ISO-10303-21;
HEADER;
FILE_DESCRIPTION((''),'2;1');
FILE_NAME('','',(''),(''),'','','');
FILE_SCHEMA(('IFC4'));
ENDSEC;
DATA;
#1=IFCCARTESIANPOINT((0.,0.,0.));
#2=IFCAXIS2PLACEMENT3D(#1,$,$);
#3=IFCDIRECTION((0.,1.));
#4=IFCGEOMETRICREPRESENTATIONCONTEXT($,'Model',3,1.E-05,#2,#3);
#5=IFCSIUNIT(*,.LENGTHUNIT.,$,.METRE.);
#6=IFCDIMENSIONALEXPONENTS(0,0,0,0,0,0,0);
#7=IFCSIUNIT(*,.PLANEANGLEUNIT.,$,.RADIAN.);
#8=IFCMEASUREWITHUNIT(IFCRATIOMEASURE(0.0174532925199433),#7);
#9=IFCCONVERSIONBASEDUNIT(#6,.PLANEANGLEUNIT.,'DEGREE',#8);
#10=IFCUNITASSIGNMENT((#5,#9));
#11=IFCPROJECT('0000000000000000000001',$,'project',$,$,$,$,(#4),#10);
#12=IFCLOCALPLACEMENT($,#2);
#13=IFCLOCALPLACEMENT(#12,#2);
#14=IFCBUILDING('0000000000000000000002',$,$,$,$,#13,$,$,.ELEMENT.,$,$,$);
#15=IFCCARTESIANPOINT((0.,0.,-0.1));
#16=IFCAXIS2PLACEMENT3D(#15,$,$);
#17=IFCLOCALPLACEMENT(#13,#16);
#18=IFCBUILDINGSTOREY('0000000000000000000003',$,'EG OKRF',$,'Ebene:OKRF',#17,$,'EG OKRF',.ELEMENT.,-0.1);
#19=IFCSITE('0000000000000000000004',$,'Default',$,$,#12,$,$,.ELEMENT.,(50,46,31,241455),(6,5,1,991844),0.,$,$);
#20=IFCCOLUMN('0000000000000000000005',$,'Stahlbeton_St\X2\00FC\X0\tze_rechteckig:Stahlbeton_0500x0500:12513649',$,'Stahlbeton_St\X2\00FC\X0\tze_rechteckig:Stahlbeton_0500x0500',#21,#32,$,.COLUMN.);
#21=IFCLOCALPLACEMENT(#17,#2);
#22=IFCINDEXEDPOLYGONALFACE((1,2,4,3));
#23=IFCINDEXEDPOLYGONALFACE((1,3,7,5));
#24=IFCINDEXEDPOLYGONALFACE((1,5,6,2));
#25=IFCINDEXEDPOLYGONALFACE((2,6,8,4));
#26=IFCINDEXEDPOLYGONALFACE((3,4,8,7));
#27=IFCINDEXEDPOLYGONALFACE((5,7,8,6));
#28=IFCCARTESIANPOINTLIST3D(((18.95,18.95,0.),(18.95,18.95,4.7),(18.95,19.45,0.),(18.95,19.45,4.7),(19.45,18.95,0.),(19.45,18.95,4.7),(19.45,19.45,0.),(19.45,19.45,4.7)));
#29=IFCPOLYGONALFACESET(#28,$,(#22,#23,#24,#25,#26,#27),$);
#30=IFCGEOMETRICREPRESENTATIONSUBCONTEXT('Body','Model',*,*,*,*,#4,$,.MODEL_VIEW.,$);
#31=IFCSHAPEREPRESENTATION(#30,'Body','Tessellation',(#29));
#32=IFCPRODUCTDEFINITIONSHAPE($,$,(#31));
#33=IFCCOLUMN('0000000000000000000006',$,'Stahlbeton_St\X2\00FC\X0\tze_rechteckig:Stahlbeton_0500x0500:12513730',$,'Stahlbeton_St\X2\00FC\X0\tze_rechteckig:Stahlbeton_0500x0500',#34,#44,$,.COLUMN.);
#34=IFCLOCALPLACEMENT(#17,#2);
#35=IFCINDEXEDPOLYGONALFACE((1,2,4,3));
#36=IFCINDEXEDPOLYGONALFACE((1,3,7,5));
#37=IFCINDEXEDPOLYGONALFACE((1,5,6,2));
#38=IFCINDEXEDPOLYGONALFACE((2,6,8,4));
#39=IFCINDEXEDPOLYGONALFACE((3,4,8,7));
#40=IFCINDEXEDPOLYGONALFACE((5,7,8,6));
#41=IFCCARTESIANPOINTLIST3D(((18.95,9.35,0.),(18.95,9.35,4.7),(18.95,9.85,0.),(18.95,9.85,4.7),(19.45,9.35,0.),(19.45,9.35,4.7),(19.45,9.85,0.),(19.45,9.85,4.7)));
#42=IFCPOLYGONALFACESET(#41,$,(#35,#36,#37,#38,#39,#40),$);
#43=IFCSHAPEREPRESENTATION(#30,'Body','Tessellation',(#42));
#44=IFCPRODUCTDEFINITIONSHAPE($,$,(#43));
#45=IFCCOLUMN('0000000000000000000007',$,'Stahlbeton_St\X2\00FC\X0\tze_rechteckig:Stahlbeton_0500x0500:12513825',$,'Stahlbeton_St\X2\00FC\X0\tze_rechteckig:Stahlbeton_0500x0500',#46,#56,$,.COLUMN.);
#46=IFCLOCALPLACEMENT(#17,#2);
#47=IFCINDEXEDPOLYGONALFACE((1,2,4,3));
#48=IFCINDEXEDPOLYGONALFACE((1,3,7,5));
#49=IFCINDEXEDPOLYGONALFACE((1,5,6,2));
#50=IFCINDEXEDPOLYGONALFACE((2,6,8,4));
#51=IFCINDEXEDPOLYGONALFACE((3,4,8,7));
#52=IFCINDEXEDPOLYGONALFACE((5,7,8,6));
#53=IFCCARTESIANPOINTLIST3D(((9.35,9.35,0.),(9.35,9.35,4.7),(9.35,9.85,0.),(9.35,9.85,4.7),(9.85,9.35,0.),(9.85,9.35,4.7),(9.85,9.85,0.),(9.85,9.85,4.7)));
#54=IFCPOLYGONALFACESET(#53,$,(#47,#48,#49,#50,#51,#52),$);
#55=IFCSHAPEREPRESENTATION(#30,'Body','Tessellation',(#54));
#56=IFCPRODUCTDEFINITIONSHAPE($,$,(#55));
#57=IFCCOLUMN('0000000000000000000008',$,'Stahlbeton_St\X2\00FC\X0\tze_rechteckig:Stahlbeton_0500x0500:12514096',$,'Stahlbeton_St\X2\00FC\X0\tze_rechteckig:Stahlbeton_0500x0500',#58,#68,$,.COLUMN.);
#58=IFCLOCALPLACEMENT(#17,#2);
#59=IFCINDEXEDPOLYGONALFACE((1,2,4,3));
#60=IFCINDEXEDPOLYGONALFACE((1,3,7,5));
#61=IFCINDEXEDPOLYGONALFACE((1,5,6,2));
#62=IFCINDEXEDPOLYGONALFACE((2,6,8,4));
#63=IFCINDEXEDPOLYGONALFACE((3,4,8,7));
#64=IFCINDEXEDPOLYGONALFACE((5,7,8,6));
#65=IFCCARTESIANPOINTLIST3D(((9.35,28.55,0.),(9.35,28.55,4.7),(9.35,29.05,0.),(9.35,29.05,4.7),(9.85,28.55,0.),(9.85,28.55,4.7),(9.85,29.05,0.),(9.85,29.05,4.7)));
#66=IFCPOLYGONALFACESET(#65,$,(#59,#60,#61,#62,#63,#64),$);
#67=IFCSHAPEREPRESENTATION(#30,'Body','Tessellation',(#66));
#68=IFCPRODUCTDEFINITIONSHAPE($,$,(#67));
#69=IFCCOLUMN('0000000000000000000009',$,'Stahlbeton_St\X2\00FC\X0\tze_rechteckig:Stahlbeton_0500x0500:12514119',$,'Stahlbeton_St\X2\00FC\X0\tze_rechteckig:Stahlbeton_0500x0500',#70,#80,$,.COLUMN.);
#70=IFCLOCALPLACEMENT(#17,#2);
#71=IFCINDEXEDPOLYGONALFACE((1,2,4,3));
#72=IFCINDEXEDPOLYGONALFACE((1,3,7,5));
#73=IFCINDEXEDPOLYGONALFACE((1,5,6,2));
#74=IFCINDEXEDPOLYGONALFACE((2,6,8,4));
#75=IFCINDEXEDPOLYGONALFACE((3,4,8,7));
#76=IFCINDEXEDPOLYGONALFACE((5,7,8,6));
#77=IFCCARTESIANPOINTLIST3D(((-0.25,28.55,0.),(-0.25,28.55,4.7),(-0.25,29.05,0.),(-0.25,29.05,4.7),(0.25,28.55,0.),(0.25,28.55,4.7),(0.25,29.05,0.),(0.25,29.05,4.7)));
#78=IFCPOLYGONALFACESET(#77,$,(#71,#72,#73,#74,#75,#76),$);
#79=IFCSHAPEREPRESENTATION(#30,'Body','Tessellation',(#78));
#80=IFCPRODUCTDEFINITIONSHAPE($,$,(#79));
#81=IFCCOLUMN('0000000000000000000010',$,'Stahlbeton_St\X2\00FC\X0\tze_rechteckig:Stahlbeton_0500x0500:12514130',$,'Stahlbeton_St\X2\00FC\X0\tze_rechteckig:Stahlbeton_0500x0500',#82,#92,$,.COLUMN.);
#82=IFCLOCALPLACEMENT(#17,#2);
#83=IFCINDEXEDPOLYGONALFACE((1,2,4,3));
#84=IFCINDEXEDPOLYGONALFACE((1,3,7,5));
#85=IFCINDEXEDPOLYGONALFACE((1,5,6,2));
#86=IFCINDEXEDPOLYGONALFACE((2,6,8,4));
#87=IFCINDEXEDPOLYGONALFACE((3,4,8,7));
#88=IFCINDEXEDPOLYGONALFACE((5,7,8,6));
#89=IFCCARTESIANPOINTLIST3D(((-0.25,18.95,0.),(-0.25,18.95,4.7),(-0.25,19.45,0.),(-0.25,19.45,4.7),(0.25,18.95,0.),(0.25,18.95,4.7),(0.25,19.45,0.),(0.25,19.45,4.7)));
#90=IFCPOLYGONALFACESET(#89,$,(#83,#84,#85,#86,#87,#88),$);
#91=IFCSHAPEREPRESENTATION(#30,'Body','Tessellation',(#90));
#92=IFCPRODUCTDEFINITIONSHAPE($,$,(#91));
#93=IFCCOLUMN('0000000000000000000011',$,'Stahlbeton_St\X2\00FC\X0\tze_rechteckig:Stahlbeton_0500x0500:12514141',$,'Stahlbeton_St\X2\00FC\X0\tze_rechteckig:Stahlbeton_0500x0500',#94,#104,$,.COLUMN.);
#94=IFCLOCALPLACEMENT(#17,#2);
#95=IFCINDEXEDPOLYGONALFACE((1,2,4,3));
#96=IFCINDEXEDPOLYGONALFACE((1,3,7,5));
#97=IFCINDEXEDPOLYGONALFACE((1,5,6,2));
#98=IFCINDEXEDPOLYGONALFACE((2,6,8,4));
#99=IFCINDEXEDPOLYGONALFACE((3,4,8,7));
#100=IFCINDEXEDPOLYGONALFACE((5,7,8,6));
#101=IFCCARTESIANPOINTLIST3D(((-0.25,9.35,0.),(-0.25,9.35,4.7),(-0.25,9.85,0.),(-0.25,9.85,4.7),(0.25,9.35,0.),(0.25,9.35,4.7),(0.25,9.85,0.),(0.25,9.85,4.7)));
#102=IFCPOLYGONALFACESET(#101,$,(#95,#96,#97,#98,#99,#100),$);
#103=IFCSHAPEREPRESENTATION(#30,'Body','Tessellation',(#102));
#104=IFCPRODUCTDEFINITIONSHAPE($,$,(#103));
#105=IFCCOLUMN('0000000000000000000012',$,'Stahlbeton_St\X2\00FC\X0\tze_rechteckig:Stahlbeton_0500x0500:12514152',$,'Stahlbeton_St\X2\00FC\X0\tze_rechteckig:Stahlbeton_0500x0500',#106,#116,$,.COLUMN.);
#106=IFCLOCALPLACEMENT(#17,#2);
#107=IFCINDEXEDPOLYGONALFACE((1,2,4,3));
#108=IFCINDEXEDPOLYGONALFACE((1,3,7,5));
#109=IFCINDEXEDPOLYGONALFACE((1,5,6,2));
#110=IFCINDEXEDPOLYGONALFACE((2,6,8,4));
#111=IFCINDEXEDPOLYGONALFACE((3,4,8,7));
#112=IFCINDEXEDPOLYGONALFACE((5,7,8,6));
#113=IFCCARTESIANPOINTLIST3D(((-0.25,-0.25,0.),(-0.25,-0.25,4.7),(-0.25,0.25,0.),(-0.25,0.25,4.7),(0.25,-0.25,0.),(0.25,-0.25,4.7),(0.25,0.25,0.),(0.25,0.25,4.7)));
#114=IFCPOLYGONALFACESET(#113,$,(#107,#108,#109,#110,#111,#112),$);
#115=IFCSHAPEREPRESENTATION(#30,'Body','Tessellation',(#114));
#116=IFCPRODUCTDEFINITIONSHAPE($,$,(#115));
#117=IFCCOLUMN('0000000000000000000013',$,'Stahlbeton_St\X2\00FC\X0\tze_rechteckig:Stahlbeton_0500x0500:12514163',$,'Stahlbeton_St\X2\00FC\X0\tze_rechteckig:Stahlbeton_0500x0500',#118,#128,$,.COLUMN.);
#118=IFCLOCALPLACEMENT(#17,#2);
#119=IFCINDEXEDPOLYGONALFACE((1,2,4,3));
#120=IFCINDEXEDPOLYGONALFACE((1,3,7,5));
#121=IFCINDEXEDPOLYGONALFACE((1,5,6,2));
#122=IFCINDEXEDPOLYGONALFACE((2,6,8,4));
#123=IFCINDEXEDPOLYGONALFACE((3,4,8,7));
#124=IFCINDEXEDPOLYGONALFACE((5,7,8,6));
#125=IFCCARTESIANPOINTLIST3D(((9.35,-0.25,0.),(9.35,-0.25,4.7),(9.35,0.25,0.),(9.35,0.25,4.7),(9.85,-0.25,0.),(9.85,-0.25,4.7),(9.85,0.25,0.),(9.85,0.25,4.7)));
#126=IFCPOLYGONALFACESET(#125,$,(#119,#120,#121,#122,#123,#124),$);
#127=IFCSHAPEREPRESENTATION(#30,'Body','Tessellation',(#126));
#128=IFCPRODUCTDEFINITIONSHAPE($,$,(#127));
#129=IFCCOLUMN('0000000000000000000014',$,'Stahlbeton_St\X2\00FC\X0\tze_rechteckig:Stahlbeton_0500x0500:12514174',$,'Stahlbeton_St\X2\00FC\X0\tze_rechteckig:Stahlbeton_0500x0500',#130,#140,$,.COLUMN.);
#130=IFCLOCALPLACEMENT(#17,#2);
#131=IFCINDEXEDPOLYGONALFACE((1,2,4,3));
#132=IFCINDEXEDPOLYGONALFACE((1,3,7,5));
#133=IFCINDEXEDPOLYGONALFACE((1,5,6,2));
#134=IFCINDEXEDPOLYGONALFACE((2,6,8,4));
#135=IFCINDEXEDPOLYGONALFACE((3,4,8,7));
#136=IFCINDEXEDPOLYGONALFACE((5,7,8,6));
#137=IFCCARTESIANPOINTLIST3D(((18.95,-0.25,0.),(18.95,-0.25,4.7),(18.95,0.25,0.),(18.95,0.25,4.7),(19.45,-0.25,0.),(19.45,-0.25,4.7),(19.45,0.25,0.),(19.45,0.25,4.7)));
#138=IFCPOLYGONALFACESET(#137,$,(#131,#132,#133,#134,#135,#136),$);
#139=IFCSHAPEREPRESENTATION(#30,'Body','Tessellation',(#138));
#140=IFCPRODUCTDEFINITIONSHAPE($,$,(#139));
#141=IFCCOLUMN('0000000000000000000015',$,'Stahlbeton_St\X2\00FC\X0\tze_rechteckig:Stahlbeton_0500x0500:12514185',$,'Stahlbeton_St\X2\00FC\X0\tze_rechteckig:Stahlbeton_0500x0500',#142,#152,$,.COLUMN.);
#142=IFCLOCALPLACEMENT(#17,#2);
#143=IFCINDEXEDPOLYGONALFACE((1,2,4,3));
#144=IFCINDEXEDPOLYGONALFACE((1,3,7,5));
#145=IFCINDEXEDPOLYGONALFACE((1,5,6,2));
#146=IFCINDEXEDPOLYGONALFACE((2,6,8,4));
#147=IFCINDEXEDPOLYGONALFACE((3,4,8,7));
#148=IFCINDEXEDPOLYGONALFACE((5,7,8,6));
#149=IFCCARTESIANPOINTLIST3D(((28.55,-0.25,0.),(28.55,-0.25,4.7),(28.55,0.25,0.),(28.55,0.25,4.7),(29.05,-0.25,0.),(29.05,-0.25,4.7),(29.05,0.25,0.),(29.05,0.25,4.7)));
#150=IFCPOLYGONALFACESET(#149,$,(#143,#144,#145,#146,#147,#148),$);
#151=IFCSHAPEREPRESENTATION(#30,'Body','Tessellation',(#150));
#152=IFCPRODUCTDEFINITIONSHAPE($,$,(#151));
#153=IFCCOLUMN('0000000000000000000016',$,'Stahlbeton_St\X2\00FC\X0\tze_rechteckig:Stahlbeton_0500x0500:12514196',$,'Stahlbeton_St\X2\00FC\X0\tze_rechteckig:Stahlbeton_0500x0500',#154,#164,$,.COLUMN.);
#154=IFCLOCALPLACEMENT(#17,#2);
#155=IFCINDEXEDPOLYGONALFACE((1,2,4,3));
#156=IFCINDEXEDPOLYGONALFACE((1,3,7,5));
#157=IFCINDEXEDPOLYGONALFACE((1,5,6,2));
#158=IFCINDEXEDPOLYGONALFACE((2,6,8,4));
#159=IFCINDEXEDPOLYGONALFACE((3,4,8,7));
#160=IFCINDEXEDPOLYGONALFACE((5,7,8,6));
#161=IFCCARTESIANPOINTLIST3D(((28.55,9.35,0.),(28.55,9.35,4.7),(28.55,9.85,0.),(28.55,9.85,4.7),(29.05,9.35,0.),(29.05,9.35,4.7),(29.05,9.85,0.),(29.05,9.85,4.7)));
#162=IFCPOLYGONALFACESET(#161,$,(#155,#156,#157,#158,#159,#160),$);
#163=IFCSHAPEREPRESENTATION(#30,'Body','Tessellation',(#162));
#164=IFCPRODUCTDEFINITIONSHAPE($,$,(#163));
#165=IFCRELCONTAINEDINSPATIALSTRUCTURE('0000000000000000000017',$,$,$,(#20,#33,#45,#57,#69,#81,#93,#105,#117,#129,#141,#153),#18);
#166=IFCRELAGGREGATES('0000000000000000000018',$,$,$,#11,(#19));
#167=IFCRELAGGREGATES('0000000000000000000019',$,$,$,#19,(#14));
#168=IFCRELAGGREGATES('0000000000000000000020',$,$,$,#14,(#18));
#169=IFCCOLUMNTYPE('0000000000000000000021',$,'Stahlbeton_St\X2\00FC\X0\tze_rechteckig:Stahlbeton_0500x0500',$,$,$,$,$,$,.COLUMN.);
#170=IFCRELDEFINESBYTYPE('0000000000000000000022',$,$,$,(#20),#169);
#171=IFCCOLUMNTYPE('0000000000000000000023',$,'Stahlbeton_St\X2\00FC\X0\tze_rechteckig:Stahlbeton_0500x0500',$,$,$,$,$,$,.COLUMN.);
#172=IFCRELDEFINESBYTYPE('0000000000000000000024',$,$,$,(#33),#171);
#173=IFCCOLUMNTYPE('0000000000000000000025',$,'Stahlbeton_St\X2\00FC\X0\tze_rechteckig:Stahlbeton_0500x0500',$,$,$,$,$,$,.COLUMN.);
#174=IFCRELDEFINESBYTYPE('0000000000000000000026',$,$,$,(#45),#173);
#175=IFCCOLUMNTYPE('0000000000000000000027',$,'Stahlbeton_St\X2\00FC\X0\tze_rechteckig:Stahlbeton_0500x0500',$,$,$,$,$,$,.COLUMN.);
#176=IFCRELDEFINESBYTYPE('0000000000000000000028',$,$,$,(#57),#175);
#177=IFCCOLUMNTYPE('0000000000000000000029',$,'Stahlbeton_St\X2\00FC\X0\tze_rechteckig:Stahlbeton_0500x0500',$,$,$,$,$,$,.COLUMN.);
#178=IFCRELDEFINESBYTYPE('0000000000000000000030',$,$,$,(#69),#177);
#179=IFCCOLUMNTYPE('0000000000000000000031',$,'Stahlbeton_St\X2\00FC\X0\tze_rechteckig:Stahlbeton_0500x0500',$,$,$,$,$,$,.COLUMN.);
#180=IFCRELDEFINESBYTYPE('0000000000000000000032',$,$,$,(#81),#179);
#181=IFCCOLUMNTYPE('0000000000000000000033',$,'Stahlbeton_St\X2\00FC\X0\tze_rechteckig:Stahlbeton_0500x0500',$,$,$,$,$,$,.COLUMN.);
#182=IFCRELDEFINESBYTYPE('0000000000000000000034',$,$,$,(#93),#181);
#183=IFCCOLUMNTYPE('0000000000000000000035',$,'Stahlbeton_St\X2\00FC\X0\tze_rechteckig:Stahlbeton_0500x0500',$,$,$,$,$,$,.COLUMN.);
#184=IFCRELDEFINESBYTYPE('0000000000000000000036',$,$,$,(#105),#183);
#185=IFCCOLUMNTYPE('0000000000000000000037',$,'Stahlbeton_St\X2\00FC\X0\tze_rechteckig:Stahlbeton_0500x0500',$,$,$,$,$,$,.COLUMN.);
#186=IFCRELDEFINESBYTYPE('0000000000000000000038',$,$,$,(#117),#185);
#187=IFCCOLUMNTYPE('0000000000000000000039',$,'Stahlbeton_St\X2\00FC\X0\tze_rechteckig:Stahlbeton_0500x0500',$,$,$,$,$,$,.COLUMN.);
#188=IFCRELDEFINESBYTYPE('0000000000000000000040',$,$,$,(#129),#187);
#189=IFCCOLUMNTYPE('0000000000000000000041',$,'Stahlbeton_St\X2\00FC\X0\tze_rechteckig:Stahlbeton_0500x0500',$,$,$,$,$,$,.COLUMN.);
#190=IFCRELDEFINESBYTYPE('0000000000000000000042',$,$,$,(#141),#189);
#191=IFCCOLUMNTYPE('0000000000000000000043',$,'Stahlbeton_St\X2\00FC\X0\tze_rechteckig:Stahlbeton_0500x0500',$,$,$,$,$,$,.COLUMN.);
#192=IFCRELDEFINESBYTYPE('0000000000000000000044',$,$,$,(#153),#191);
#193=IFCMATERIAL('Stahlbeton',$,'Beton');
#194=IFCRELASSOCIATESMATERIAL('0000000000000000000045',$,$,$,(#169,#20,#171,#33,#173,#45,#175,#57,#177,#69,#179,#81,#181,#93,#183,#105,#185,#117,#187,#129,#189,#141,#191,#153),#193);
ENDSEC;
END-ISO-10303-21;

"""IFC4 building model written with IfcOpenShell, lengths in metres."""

from ifc_helpers import new_model, entity, si_unit, converted_unit, direction, frame, origin, place, context, subcontext, project, spatial, indexed_curve, outline, extrude, source, transform, mapped, material, type_object, type_shapes, element, save


model = new_model("IFC4")

# Units and contexts
model_context = context("Model", 3, precision=1e-05, world=origin(), true_north=direction((0.0, 1.0)))
body_context = subcontext(model_context, "Body", "Model", "MODEL_VIEW")
ifc_project = project(units=[si_unit("LENGTHUNIT", "METRE"), converted_unit("PLANEANGLEUNIT", "DEGREE", entity("IfcRatioMeasure", 0.0174532925199433), si_unit("PLANEANGLEUNIT", "RADIAN"), dimensions=[0, 0, 0, 0, 0, 0, 0])], contexts=[model_context])

# Site, building, storey
site_placement = place(None, origin())
site = spatial("IfcSite", under=ifc_project, at=site_placement, Name="Default", CompositionType="ELEMENT", RefLatitude=(50, 46, 31, 241455), RefLongitude=(6, 5, 1, 991844), RefElevation=0.0)
building_placement = place(site_placement, origin())
building = spatial("IfcBuilding", under=site, at=building_placement, CompositionType="ELEMENT")
storey_placement = place(building_placement, frame((0.0, 0.0, -0.1)))
storey = spatial("IfcBuildingStorey", under=building, at=storey_placement, Name="EG OKRF", ObjectType="Ebene:OKRF", LongName="EG OKRF", CompositionType="ELEMENT", Elevation=-0.1)

# Columns
ifc_material_1 = material(Name="Stahlbeton", Category="Beton")
column_type_1 = type_object("IfcColumnType", Name="Stahlbeton_Stütze_rechteckig:Stahlbeton_0500x0500", PredefinedType="COLUMN", material=ifc_material_1)
shared_shape_1 = source(origin(), body_context, "Body", "SweptSolid", [
    extrude(outline(indexed_curve([(-0.25, -0.25), (0.25, -0.25), (0.25, 0.25), (-0.25, 0.25), (-0.25, -0.25)], self_intersect=False)), frame((19.2, 19.2, -0.1), z_axis=(0.0, 0.0, 1.0), x_axis=(0.0, -1.0, 0.0)), (0.0, 0.0, 1.0), 4.7),
])
type_shapes(column_type_1, [shared_shape_1])
column_1_placement = place(storey_placement, frame((0.0, 0.0, 0.1)))
element("IfcColumn", 1, at=column_1_placement, inside=storey, type_object=column_type_1, material=ifc_material_1, Name="Stahlbeton_Stütze_rechteckig:Stahlbeton_0500x0500:12513649", ObjectType="Stahlbeton_Stütze_rechteckig:Stahlbeton_0500x0500", PredefinedType="COLUMN", context=body_context, shape_type="MappedRepresentation", body=[
    mapped(shared_shape_1, transform((0.0, 0.0, 0.0), scale=1.0)),
])
column_type_2 = type_object("IfcColumnType", Name="Stahlbeton_Stütze_rechteckig:Stahlbeton_0500x0500", PredefinedType="COLUMN", material=ifc_material_1)
shared_shape_2 = source(origin(), body_context, "Body", "SweptSolid", [
    extrude(outline(indexed_curve([(-0.25, -0.25), (0.25, -0.25), (0.25, 0.25), (-0.25, 0.25), (-0.25, -0.25)], self_intersect=False)), frame((19.2, 9.6, -0.1), z_axis=(0.0, 0.0, 1.0), x_axis=(0.0, -1.0, 0.0)), (0.0, 0.0, 1.0), 4.7),
])
type_shapes(column_type_2, [shared_shape_2])
column_2_placement = place(storey_placement, frame((0.0, 0.0, 0.1)))
element("IfcColumn", 2, at=column_2_placement, inside=storey, type_object=column_type_2, material=ifc_material_1, Name="Stahlbeton_Stütze_rechteckig:Stahlbeton_0500x0500:12513730", ObjectType="Stahlbeton_Stütze_rechteckig:Stahlbeton_0500x0500", PredefinedType="COLUMN", context=body_context, shape_type="MappedRepresentation", body=[
    mapped(shared_shape_2, transform((0.0, 0.0, 0.0), scale=1.0)),
])
column_type_3 = type_object("IfcColumnType", Name="Stahlbeton_Stütze_rechteckig:Stahlbeton_0500x0500", PredefinedType="COLUMN", material=ifc_material_1)
shared_shape_3 = source(origin(), body_context, "Body", "SweptSolid", [
    extrude(outline(indexed_curve([(-0.25, -0.25), (0.25, -0.25), (0.25, 0.25), (-0.25, 0.25), (-0.25, -0.25)], self_intersect=False)), frame((9.6, 9.6, -0.1), z_axis=(0.0, 0.0, 1.0), x_axis=(0.0, -1.0, 0.0)), (0.0, 0.0, 1.0), 4.7),
])
type_shapes(column_type_3, [shared_shape_3])
column_3_placement = place(storey_placement, frame((0.0, 0.0, 0.1)))
element("IfcColumn", 3, at=column_3_placement, inside=storey, type_object=column_type_3, material=ifc_material_1, Name="Stahlbeton_Stütze_rechteckig:Stahlbeton_0500x0500:12513825", ObjectType="Stahlbeton_Stütze_rechteckig:Stahlbeton_0500x0500", PredefinedType="COLUMN", context=body_context, shape_type="MappedRepresentation", body=[
    mapped(shared_shape_3, transform((0.0, 0.0, 0.0), scale=1.0)),
])
column_type_4 = type_object("IfcColumnType", Name="Stahlbeton_Stütze_rechteckig:Stahlbeton_0500x0500", PredefinedType="COLUMN", material=ifc_material_1)
shared_shape_4 = source(origin(), body_context, "Body", "SweptSolid", [
    extrude(outline(indexed_curve([(-0.25, -0.25), (0.25, -0.25), (0.25, 0.25), (-0.25, 0.25), (-0.25, -0.25)], self_intersect=False)), frame((9.6, 28.8, -0.1), z_axis=(0.0, 0.0, 1.0), x_axis=(0.0, -1.0, 0.0)), (0.0, 0.0, 1.0), 4.7),
])
type_shapes(column_type_4, [shared_shape_4])
column_4_placement = place(storey_placement, frame((0.0, 0.0, 0.1)))
element("IfcColumn", 4, at=column_4_placement, inside=storey, type_object=column_type_4, material=ifc_material_1, Name="Stahlbeton_Stütze_rechteckig:Stahlbeton_0500x0500:12514096", ObjectType="Stahlbeton_Stütze_rechteckig:Stahlbeton_0500x0500", PredefinedType="COLUMN", context=body_context, shape_type="MappedRepresentation", body=[
    mapped(shared_shape_4, transform((0.0, 0.0, 0.0), scale=1.0)),
])
column_type_5 = type_object("IfcColumnType", Name="Stahlbeton_Stütze_rechteckig:Stahlbeton_0500x0500", PredefinedType="COLUMN", material=ifc_material_1)
shared_shape_5 = source(origin(), body_context, "Body", "SweptSolid", [
    extrude(outline(indexed_curve([(-0.25, -0.25), (0.25, -0.25), (0.25, 0.25), (-0.25, 0.25), (-0.25, -0.25)], self_intersect=False)), frame((0.0, 28.8, -0.1), z_axis=(0.0, 0.0, 1.0), x_axis=(0.0, -1.0, 0.0)), (0.0, 0.0, 1.0), 4.7),
])
type_shapes(column_type_5, [shared_shape_5])
column_5_placement = place(storey_placement, frame((0.0, 0.0, 0.1)))
element("IfcColumn", 5, at=column_5_placement, inside=storey, type_object=column_type_5, material=ifc_material_1, Name="Stahlbeton_Stütze_rechteckig:Stahlbeton_0500x0500:12514119", ObjectType="Stahlbeton_Stütze_rechteckig:Stahlbeton_0500x0500", PredefinedType="COLUMN", context=body_context, shape_type="MappedRepresentation", body=[
    mapped(shared_shape_5, transform((0.0, 0.0, 0.0), scale=1.0)),
])
column_type_6 = type_object("IfcColumnType", Name="Stahlbeton_Stütze_rechteckig:Stahlbeton_0500x0500", PredefinedType="COLUMN", material=ifc_material_1)
shared_shape_6 = source(origin(), body_context, "Body", "SweptSolid", [
    extrude(outline(indexed_curve([(-0.25, -0.25), (0.25, -0.25), (0.25, 0.25), (-0.25, 0.25), (-0.25, -0.25)], self_intersect=False)), frame((0.0, 19.2, -0.1), z_axis=(0.0, 0.0, 1.0), x_axis=(0.0, -1.0, 0.0)), (0.0, 0.0, 1.0), 4.7),
])
type_shapes(column_type_6, [shared_shape_6])
column_6_placement = place(storey_placement, frame((0.0, 0.0, 0.1)))
element("IfcColumn", 6, at=column_6_placement, inside=storey, type_object=column_type_6, material=ifc_material_1, Name="Stahlbeton_Stütze_rechteckig:Stahlbeton_0500x0500:12514130", ObjectType="Stahlbeton_Stütze_rechteckig:Stahlbeton_0500x0500", PredefinedType="COLUMN", context=body_context, shape_type="MappedRepresentation", body=[
    mapped(shared_shape_6, transform((0.0, 0.0, 0.0), scale=1.0)),
])
column_type_7 = type_object("IfcColumnType", Name="Stahlbeton_Stütze_rechteckig:Stahlbeton_0500x0500", PredefinedType="COLUMN", material=ifc_material_1)
shared_shape_7 = source(origin(), body_context, "Body", "SweptSolid", [
    extrude(outline(indexed_curve([(-0.25, -0.25), (0.25, -0.25), (0.25, 0.25), (-0.25, 0.25), (-0.25, -0.25)], self_intersect=False)), frame((0.0, 9.6, -0.1), z_axis=(0.0, 0.0, 1.0), x_axis=(0.0, -1.0, 0.0)), (0.0, 0.0, 1.0), 4.7),
])
type_shapes(column_type_7, [shared_shape_7])
column_7_placement = place(storey_placement, frame((0.0, 0.0, 0.1)))
element("IfcColumn", 7, at=column_7_placement, inside=storey, type_object=column_type_7, material=ifc_material_1, Name="Stahlbeton_Stütze_rechteckig:Stahlbeton_0500x0500:12514141", ObjectType="Stahlbeton_Stütze_rechteckig:Stahlbeton_0500x0500", PredefinedType="COLUMN", context=body_context, shape_type="MappedRepresentation", body=[
    mapped(shared_shape_7, transform((0.0, 0.0, 0.0), scale=1.0)),
])
column_type_8 = type_object("IfcColumnType", Name="Stahlbeton_Stütze_rechteckig:Stahlbeton_0500x0500", PredefinedType="COLUMN", material=ifc_material_1)
shared_shape_8 = source(origin(), body_context, "Body", "SweptSolid", [
    extrude(outline(indexed_curve([(-0.25, -0.25), (0.25, -0.25), (0.25, 0.25), (-0.25, 0.25), (-0.25, -0.25)], self_intersect=False)), frame((0.0, 0.0, -0.1), z_axis=(0.0, 0.0, 1.0), x_axis=(0.0, -1.0, 0.0)), (0.0, 0.0, 1.0), 4.7),
])
type_shapes(column_type_8, [shared_shape_8])
column_8_placement = place(storey_placement, frame((0.0, 0.0, 0.1)))
element("IfcColumn", 8, at=column_8_placement, inside=storey, type_object=column_type_8, material=ifc_material_1, Name="Stahlbeton_Stütze_rechteckig:Stahlbeton_0500x0500:12514152", ObjectType="Stahlbeton_Stütze_rechteckig:Stahlbeton_0500x0500", PredefinedType="COLUMN", context=body_context, shape_type="MappedRepresentation", body=[
    mapped(shared_shape_8, transform((0.0, 0.0, 0.0), scale=1.0)),
])
column_type_9 = type_object("IfcColumnType", Name="Stahlbeton_Stütze_rechteckig:Stahlbeton_0500x0500", PredefinedType="COLUMN", material=ifc_material_1)
shared_shape_9 = source(origin(), body_context, "Body", "SweptSolid", [
    extrude(outline(indexed_curve([(-0.25, -0.25), (0.25, -0.25), (0.25, 0.25), (-0.25, 0.25), (-0.25, -0.25)], self_intersect=False)), frame((9.6, 0.0, -0.1), z_axis=(0.0, 0.0, 1.0), x_axis=(0.0, -1.0, 0.0)), (0.0, 0.0, 1.0), 4.7),
])
type_shapes(column_type_9, [shared_shape_9])
column_9_placement = place(storey_placement, frame((0.0, 0.0, 0.1)))
element("IfcColumn", 9, at=column_9_placement, inside=storey, type_object=column_type_9, material=ifc_material_1, Name="Stahlbeton_Stütze_rechteckig:Stahlbeton_0500x0500:12514163", ObjectType="Stahlbeton_Stütze_rechteckig:Stahlbeton_0500x0500", PredefinedType="COLUMN", context=body_context, shape_type="MappedRepresentation", body=[
    mapped(shared_shape_9, transform((0.0, 0.0, 0.0), scale=1.0)),
])
column_type_10 = type_object("IfcColumnType", Name="Stahlbeton_Stütze_rechteckig:Stahlbeton_0500x0500", PredefinedType="COLUMN", material=ifc_material_1)
shared_shape_10 = source(origin(), body_context, "Body", "SweptSolid", [
    extrude(outline(indexed_curve([(-0.25, -0.25), (0.25, -0.25), (0.25, 0.25), (-0.25, 0.25), (-0.25, -0.25)], self_intersect=False)), frame((19.2, 0.0, -0.1), z_axis=(0.0, 0.0, 1.0), x_axis=(0.0, -1.0, 0.0)), (0.0, 0.0, 1.0), 4.7),
])
type_shapes(column_type_10, [shared_shape_10])
column_10_placement = place(storey_placement, frame((0.0, 0.0, 0.1)))
element("IfcColumn", 10, at=column_10_placement, inside=storey, type_object=column_type_10, material=ifc_material_1, Name="Stahlbeton_Stütze_rechteckig:Stahlbeton_0500x0500:12514174", ObjectType="Stahlbeton_Stütze_rechteckig:Stahlbeton_0500x0500", PredefinedType="COLUMN", context=body_context, shape_type="MappedRepresentation", body=[
    mapped(shared_shape_10, transform((0.0, 0.0, 0.0), scale=1.0)),
])
column_type_11 = type_object("IfcColumnType", Name="Stahlbeton_Stütze_rechteckig:Stahlbeton_0500x0500", PredefinedType="COLUMN", material=ifc_material_1)
shared_shape_11 = source(origin(), body_context, "Body", "SweptSolid", [
    extrude(outline(indexed_curve([(-0.25, -0.25), (0.25, -0.25), (0.25, 0.25), (-0.25, 0.25), (-0.25, -0.25)], self_intersect=False)), frame((28.8, 0.0, -0.1), z_axis=(0.0, 0.0, 1.0), x_axis=(0.0, -1.0, 0.0)), (0.0, 0.0, 1.0), 4.7),
])
type_shapes(column_type_11, [shared_shape_11])
column_11_placement = place(storey_placement, frame((0.0, 0.0, 0.1)))
element("IfcColumn", 11, at=column_11_placement, inside=storey, type_object=column_type_11, material=ifc_material_1, Name="Stahlbeton_Stütze_rechteckig:Stahlbeton_0500x0500:12514185", ObjectType="Stahlbeton_Stütze_rechteckig:Stahlbeton_0500x0500", PredefinedType="COLUMN", context=body_context, shape_type="MappedRepresentation", body=[
    mapped(shared_shape_11, transform((0.0, 0.0, 0.0), scale=1.0)),
])
column_type_12 = type_object("IfcColumnType", Name="Stahlbeton_Stütze_rechteckig:Stahlbeton_0500x0500", PredefinedType="COLUMN", material=ifc_material_1)
shared_shape_12 = source(origin(), body_context, "Body", "SweptSolid", [
    extrude(outline(indexed_curve([(-0.25, -0.25), (0.25, -0.25), (0.25, 0.25), (-0.25, 0.25), (-0.25, -0.25)], self_intersect=False)), frame((28.8, 9.6, -0.1), z_axis=(0.0, 0.0, 1.0), x_axis=(0.0, -1.0, 0.0)), (0.0, 0.0, 1.0), 4.7),
])
type_shapes(column_type_12, [shared_shape_12])
column_12_placement = place(storey_placement, frame((0.0, 0.0, 0.1)))
element("IfcColumn", 12, at=column_12_placement, inside=storey, type_object=column_type_12, material=ifc_material_1, Name="Stahlbeton_Stütze_rechteckig:Stahlbeton_0500x0500:12514196", ObjectType="Stahlbeton_Stütze_rechteckig:Stahlbeton_0500x0500", PredefinedType="COLUMN", context=body_context, shape_type="MappedRepresentation", body=[
    mapped(shared_shape_12, transform((0.0, 0.0, 0.0), scale=1.0)),
])

save(model, "model.ifc")
